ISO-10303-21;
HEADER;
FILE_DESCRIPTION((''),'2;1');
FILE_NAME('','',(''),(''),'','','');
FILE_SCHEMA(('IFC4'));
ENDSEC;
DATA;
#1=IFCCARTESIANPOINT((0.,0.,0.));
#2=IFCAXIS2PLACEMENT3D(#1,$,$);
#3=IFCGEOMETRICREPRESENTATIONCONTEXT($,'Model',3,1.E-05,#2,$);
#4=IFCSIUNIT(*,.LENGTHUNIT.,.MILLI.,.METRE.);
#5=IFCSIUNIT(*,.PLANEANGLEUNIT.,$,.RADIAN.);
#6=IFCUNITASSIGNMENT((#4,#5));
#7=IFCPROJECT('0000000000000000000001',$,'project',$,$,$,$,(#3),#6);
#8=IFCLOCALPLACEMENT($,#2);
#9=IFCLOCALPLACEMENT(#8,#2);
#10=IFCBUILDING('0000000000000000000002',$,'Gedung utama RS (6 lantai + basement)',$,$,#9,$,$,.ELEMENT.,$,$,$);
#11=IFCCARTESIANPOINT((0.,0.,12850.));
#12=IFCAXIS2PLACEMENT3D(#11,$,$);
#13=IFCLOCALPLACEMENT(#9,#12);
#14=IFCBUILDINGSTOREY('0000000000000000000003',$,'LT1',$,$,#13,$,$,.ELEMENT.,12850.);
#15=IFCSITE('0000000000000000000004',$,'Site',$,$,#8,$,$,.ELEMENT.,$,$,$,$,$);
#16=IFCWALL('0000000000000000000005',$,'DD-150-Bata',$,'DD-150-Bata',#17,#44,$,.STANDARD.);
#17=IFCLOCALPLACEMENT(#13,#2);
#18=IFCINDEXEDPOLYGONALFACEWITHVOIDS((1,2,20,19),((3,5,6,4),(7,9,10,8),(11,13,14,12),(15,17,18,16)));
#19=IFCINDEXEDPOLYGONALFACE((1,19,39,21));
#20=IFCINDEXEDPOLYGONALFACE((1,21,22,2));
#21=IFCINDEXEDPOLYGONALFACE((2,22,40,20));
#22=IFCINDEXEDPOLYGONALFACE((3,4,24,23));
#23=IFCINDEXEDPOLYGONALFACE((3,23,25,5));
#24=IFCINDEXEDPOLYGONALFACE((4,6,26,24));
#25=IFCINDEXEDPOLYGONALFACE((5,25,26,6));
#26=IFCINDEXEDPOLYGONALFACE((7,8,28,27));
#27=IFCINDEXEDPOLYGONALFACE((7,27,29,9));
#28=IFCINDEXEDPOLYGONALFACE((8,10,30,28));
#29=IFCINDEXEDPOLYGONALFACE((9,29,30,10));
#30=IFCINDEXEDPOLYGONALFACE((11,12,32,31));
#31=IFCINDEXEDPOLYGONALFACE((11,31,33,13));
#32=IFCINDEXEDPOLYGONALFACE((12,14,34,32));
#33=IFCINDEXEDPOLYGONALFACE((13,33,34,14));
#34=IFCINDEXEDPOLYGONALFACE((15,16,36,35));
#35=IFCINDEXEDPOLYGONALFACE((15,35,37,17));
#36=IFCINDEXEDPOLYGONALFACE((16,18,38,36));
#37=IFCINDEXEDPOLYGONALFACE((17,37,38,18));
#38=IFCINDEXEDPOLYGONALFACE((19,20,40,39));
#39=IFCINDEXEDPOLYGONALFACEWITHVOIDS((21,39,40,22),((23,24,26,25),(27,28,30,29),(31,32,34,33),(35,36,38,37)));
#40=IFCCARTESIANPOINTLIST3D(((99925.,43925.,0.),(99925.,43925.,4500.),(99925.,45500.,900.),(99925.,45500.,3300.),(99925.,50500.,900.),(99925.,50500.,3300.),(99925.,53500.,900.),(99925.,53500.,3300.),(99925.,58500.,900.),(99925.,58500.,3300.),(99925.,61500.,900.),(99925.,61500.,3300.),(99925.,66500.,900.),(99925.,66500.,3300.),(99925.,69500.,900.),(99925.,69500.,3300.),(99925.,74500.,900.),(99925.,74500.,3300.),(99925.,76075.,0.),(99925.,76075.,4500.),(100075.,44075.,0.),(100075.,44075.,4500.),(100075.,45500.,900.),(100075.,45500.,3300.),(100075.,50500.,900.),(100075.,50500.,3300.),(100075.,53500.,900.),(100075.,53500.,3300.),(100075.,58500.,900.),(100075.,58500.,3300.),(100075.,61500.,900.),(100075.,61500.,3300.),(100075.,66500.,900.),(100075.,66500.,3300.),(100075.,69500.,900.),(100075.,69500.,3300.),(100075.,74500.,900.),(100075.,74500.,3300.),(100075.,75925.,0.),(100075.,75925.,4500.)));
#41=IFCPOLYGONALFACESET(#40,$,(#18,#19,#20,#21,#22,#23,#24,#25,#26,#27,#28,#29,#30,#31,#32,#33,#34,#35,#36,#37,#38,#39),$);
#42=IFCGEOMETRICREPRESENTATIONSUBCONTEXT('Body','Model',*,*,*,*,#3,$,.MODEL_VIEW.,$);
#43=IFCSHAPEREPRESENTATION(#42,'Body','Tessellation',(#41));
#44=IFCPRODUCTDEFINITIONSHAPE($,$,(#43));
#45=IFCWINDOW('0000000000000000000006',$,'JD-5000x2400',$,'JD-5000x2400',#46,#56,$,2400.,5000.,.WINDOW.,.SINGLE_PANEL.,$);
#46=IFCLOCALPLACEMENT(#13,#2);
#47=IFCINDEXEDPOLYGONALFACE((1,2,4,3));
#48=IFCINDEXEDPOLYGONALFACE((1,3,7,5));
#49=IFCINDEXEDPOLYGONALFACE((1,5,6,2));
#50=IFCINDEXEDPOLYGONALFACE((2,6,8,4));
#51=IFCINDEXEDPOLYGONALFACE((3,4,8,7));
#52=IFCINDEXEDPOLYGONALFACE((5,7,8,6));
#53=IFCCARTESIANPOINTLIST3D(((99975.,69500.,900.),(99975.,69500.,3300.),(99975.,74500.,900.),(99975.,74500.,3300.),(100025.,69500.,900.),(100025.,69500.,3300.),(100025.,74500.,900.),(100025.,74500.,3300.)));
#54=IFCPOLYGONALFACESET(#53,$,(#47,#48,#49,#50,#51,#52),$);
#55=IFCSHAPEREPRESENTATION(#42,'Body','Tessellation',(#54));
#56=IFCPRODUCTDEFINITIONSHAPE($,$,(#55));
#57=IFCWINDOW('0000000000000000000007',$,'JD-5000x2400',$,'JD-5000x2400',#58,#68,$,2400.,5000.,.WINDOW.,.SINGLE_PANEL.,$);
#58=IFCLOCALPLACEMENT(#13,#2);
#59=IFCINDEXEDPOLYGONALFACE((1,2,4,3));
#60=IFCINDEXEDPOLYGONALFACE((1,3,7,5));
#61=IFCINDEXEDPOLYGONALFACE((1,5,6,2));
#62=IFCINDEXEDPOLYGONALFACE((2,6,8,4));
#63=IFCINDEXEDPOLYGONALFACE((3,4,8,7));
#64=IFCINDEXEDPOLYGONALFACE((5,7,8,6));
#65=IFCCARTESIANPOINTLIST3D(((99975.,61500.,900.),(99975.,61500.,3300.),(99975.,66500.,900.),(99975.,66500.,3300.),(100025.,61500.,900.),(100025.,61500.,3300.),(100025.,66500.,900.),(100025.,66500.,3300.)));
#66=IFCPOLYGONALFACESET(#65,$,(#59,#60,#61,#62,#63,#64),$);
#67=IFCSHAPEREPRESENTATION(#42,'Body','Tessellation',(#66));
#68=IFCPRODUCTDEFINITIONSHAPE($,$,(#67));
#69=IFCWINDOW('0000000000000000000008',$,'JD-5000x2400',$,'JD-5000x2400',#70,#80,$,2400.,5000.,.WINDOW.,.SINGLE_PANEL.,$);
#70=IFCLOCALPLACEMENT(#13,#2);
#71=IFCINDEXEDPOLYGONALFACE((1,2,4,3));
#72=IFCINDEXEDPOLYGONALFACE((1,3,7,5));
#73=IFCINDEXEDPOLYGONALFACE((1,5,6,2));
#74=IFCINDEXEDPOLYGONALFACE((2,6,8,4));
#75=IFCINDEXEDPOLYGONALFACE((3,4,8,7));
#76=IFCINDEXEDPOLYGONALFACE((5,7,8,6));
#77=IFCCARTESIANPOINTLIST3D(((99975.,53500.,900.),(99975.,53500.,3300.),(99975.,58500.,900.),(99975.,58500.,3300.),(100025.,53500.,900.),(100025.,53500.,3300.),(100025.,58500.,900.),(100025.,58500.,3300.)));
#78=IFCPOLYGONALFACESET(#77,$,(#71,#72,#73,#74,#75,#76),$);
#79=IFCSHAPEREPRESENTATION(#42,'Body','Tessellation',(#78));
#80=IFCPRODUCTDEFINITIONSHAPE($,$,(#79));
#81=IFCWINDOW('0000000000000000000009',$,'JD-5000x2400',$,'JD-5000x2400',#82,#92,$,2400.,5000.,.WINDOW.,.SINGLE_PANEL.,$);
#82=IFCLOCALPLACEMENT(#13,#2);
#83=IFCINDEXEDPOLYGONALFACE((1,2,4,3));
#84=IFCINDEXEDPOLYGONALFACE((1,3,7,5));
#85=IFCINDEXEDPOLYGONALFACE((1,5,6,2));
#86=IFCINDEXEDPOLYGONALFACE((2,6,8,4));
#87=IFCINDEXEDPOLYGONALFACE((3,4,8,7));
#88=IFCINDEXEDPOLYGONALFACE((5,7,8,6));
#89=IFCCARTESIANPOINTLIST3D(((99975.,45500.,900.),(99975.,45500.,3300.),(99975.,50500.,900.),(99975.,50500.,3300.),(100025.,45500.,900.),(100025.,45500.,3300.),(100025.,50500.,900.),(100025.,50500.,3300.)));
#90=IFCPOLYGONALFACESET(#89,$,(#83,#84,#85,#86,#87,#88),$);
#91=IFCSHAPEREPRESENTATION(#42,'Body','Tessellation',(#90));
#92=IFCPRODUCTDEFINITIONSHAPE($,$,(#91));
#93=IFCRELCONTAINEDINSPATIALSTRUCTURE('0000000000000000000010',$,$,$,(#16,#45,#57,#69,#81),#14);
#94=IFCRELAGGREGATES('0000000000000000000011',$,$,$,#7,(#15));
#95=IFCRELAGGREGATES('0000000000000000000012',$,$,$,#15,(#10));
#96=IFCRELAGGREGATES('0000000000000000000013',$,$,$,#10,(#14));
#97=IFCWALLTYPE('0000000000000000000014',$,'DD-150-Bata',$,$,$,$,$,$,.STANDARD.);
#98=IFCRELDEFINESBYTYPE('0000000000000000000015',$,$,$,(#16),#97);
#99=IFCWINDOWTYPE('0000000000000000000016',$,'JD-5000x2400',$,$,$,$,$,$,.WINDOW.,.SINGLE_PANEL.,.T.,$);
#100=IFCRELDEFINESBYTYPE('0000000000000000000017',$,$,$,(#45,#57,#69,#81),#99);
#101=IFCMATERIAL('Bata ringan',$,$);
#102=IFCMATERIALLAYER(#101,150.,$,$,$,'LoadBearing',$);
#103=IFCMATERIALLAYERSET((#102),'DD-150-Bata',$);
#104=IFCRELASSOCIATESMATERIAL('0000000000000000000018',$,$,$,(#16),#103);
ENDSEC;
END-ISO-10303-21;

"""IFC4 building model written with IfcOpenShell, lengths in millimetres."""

from ifc_helpers import new_model, si_unit, frame, frame_2d, origin, place, context, subcontext, project, spatial, polyline, rectangle, outline, extrude, material, layer, layer_set, layer_usage, type_object, element, fill, save


model = new_model("IFC4")

# Units and contexts
model_context = context("Model", 3, precision=1e-05, world=origin())
body_context = subcontext(model_context, "Body", "Model", "MODEL_VIEW")
ifc_project = project(units=[si_unit("LENGTHUNIT", "METRE", prefix="MILLI"), si_unit("PLANEANGLEUNIT", "RADIAN")], contexts=[model_context])

# Site, building, storey
site_placement = place(None, origin())
site = spatial("IfcSite", under=ifc_project, at=site_placement, Name="Site", CompositionType="ELEMENT")
building_placement = place(site_placement, origin())
building = spatial("IfcBuilding", under=site, at=building_placement, Name="Gedung utama RS (6 lantai + basement)", CompositionType="ELEMENT")
storey_placement = place(building_placement, frame((0.0, 0.0, 12850.0)))
storey = spatial("IfcBuildingStorey", under=building, at=storey_placement, Name="LT1", CompositionType="ELEMENT", Elevation=12850.0)

# Wall, openings, windows
ifc_material_1 = material(Name="Bata ringan")
ifc_layer = layer(ifc_material_1, 150.0, Category="LoadBearing")
ifc_layer_set = layer_set([ifc_layer], Name="DD-150-Bata")
ifc_layer_usage = layer_usage(ifc_layer_set, "AXIS2", "NEGATIVE", 75.0)
wall_type = type_object("IfcWallType", Name="DD-150-Bata", PredefinedType="STANDARD")
wall_placement = place(storey_placement, frame((100000.0, 76000.0, 0.0), z_axis=(0.0, 0.0, 1.0), x_axis=(0.0, -1.0, 0.0)))
wall = element("IfcWall", 1, at=wall_placement, inside=storey, type_object=wall_type, material=ifc_layer_usage, Name="DD-150-Bata", ObjectType="DD-150-Bata", PredefinedType="STANDARD", context=body_context, shape_type="SweptSolid", body=[
    extrude(outline(polyline([(-75.0, -75.0), (0.0, 0.0), (75.0, 75.0), (31925.0, 75.0), (32000.0, 0.0), (32075.0, -75.0), (-75.0, -75.0)])), origin(), (0.0, 0.0, 1.0), 4500.0),
])
opening_1_placement = place(wall_placement, frame((1500.0, 0.0, 900.0), z_axis=(0.0, 0.0, 1.0), x_axis=(1.0, 0.0, 0.0)))
opening_1 = element("IfcOpeningElement", 2, at=opening_1_placement, cuts=wall, PredefinedType="OPENING", context=body_context, shape_type="SweptSolid", body=[
    extrude(rectangle(XDim=5000.0, YDim=170.0, at=frame_2d((2500.0, 0.0))), origin(), (0.0, 0.0, 1.0), 2400.0),
])
opening_2_placement = place(wall_placement, frame((9500.0, 0.0, 900.0), z_axis=(0.0, 0.0, 1.0), x_axis=(1.0, 0.0, 0.0)))
opening_2 = element("IfcOpeningElement", 3, at=opening_2_placement, cuts=wall, PredefinedType="OPENING", context=body_context, shape_type="SweptSolid", body=[
    extrude(rectangle(XDim=5000.0, YDim=170.0, at=frame_2d((2500.0, 0.0))), origin(), (0.0, 0.0, 1.0), 2400.0),
])
opening_3_placement = place(wall_placement, frame((17500.0, 0.0, 900.0), z_axis=(0.0, 0.0, 1.0), x_axis=(1.0, 0.0, 0.0)))
opening_3 = element("IfcOpeningElement", 4, at=opening_3_placement, cuts=wall, PredefinedType="OPENING", context=body_context, shape_type="SweptSolid", body=[
    extrude(rectangle(XDim=5000.0, YDim=170.0, at=frame_2d((2500.0, 0.0))), origin(), (0.0, 0.0, 1.0), 2400.0),
])
opening_4_placement = place(wall_placement, frame((25500.0, 0.0, 900.0), z_axis=(0.0, 0.0, 1.0), x_axis=(1.0, 0.0, 0.0)))
opening_4 = element("IfcOpeningElement", 5, at=opening_4_placement, cuts=wall, PredefinedType="OPENING", context=body_context, shape_type="SweptSolid", body=[
    extrude(rectangle(XDim=5000.0, YDim=170.0, at=frame_2d((2500.0, 0.0))), origin(), (0.0, 0.0, 1.0), 2400.0),
])
window_type = type_object("IfcWindowType", Name="JD-5000x2400", ParameterTakesPrecedence=True, PartitioningType="SINGLE_PANEL", PredefinedType="WINDOW")
window_1_placement = place(opening_1_placement, origin())
window_1 = element("IfcWindow", 6, at=window_1_placement, inside=storey, type_object=window_type, Name="JD-5000x2400", ObjectType="JD-5000x2400", OverallHeight=2400.0, OverallWidth=5000.0, PartitioningType="SINGLE_PANEL", PredefinedType="WINDOW", context=body_context, shape_type="SweptSolid", body=[
    extrude(rectangle(XDim=5000.0, YDim=50.0, at=frame_2d((2500.0, 0.0))), origin(), (0.0, 0.0, 1.0), 2400.0),
])
fill(opening_1, window_1)
window_2_placement = place(opening_2_placement, origin())
window_2 = element("IfcWindow", 7, at=window_2_placement, inside=storey, type_object=window_type, Name="JD-5000x2400", ObjectType="JD-5000x2400", OverallHeight=2400.0, OverallWidth=5000.0, PartitioningType="SINGLE_PANEL", PredefinedType="WINDOW", context=body_context, shape_type="SweptSolid", body=[
    extrude(rectangle(XDim=5000.0, YDim=50.0, at=frame_2d((2500.0, 0.0))), origin(), (0.0, 0.0, 1.0), 2400.0),
])
fill(opening_2, window_2)
window_3_placement = place(opening_3_placement, origin())
window_3 = element("IfcWindow", 8, at=window_3_placement, inside=storey, type_object=window_type, Name="JD-5000x2400", ObjectType="JD-5000x2400", OverallHeight=2400.0, OverallWidth=5000.0, PartitioningType="SINGLE_PANEL", PredefinedType="WINDOW", context=body_context, shape_type="SweptSolid", body=[
    extrude(rectangle(XDim=5000.0, YDim=50.0, at=frame_2d((2500.0, 0.0))), origin(), (0.0, 0.0, 1.0), 2400.0),
])
fill(opening_3, window_3)
window_4_placement = place(opening_4_placement, origin())
window_4 = element("IfcWindow", 9, at=window_4_placement, inside=storey, type_object=window_type, Name="JD-5000x2400", ObjectType="JD-5000x2400", OverallHeight=2400.0, OverallWidth=5000.0, PartitioningType="SINGLE_PANEL", PredefinedType="WINDOW", context=body_context, shape_type="SweptSolid", body=[
    extrude(rectangle(XDim=5000.0, YDim=50.0, at=frame_2d((2500.0, 0.0))), origin(), (0.0, 0.0, 1.0), 2400.0),
])
fill(opening_4, window_4)

save(model, "model.ifc")
